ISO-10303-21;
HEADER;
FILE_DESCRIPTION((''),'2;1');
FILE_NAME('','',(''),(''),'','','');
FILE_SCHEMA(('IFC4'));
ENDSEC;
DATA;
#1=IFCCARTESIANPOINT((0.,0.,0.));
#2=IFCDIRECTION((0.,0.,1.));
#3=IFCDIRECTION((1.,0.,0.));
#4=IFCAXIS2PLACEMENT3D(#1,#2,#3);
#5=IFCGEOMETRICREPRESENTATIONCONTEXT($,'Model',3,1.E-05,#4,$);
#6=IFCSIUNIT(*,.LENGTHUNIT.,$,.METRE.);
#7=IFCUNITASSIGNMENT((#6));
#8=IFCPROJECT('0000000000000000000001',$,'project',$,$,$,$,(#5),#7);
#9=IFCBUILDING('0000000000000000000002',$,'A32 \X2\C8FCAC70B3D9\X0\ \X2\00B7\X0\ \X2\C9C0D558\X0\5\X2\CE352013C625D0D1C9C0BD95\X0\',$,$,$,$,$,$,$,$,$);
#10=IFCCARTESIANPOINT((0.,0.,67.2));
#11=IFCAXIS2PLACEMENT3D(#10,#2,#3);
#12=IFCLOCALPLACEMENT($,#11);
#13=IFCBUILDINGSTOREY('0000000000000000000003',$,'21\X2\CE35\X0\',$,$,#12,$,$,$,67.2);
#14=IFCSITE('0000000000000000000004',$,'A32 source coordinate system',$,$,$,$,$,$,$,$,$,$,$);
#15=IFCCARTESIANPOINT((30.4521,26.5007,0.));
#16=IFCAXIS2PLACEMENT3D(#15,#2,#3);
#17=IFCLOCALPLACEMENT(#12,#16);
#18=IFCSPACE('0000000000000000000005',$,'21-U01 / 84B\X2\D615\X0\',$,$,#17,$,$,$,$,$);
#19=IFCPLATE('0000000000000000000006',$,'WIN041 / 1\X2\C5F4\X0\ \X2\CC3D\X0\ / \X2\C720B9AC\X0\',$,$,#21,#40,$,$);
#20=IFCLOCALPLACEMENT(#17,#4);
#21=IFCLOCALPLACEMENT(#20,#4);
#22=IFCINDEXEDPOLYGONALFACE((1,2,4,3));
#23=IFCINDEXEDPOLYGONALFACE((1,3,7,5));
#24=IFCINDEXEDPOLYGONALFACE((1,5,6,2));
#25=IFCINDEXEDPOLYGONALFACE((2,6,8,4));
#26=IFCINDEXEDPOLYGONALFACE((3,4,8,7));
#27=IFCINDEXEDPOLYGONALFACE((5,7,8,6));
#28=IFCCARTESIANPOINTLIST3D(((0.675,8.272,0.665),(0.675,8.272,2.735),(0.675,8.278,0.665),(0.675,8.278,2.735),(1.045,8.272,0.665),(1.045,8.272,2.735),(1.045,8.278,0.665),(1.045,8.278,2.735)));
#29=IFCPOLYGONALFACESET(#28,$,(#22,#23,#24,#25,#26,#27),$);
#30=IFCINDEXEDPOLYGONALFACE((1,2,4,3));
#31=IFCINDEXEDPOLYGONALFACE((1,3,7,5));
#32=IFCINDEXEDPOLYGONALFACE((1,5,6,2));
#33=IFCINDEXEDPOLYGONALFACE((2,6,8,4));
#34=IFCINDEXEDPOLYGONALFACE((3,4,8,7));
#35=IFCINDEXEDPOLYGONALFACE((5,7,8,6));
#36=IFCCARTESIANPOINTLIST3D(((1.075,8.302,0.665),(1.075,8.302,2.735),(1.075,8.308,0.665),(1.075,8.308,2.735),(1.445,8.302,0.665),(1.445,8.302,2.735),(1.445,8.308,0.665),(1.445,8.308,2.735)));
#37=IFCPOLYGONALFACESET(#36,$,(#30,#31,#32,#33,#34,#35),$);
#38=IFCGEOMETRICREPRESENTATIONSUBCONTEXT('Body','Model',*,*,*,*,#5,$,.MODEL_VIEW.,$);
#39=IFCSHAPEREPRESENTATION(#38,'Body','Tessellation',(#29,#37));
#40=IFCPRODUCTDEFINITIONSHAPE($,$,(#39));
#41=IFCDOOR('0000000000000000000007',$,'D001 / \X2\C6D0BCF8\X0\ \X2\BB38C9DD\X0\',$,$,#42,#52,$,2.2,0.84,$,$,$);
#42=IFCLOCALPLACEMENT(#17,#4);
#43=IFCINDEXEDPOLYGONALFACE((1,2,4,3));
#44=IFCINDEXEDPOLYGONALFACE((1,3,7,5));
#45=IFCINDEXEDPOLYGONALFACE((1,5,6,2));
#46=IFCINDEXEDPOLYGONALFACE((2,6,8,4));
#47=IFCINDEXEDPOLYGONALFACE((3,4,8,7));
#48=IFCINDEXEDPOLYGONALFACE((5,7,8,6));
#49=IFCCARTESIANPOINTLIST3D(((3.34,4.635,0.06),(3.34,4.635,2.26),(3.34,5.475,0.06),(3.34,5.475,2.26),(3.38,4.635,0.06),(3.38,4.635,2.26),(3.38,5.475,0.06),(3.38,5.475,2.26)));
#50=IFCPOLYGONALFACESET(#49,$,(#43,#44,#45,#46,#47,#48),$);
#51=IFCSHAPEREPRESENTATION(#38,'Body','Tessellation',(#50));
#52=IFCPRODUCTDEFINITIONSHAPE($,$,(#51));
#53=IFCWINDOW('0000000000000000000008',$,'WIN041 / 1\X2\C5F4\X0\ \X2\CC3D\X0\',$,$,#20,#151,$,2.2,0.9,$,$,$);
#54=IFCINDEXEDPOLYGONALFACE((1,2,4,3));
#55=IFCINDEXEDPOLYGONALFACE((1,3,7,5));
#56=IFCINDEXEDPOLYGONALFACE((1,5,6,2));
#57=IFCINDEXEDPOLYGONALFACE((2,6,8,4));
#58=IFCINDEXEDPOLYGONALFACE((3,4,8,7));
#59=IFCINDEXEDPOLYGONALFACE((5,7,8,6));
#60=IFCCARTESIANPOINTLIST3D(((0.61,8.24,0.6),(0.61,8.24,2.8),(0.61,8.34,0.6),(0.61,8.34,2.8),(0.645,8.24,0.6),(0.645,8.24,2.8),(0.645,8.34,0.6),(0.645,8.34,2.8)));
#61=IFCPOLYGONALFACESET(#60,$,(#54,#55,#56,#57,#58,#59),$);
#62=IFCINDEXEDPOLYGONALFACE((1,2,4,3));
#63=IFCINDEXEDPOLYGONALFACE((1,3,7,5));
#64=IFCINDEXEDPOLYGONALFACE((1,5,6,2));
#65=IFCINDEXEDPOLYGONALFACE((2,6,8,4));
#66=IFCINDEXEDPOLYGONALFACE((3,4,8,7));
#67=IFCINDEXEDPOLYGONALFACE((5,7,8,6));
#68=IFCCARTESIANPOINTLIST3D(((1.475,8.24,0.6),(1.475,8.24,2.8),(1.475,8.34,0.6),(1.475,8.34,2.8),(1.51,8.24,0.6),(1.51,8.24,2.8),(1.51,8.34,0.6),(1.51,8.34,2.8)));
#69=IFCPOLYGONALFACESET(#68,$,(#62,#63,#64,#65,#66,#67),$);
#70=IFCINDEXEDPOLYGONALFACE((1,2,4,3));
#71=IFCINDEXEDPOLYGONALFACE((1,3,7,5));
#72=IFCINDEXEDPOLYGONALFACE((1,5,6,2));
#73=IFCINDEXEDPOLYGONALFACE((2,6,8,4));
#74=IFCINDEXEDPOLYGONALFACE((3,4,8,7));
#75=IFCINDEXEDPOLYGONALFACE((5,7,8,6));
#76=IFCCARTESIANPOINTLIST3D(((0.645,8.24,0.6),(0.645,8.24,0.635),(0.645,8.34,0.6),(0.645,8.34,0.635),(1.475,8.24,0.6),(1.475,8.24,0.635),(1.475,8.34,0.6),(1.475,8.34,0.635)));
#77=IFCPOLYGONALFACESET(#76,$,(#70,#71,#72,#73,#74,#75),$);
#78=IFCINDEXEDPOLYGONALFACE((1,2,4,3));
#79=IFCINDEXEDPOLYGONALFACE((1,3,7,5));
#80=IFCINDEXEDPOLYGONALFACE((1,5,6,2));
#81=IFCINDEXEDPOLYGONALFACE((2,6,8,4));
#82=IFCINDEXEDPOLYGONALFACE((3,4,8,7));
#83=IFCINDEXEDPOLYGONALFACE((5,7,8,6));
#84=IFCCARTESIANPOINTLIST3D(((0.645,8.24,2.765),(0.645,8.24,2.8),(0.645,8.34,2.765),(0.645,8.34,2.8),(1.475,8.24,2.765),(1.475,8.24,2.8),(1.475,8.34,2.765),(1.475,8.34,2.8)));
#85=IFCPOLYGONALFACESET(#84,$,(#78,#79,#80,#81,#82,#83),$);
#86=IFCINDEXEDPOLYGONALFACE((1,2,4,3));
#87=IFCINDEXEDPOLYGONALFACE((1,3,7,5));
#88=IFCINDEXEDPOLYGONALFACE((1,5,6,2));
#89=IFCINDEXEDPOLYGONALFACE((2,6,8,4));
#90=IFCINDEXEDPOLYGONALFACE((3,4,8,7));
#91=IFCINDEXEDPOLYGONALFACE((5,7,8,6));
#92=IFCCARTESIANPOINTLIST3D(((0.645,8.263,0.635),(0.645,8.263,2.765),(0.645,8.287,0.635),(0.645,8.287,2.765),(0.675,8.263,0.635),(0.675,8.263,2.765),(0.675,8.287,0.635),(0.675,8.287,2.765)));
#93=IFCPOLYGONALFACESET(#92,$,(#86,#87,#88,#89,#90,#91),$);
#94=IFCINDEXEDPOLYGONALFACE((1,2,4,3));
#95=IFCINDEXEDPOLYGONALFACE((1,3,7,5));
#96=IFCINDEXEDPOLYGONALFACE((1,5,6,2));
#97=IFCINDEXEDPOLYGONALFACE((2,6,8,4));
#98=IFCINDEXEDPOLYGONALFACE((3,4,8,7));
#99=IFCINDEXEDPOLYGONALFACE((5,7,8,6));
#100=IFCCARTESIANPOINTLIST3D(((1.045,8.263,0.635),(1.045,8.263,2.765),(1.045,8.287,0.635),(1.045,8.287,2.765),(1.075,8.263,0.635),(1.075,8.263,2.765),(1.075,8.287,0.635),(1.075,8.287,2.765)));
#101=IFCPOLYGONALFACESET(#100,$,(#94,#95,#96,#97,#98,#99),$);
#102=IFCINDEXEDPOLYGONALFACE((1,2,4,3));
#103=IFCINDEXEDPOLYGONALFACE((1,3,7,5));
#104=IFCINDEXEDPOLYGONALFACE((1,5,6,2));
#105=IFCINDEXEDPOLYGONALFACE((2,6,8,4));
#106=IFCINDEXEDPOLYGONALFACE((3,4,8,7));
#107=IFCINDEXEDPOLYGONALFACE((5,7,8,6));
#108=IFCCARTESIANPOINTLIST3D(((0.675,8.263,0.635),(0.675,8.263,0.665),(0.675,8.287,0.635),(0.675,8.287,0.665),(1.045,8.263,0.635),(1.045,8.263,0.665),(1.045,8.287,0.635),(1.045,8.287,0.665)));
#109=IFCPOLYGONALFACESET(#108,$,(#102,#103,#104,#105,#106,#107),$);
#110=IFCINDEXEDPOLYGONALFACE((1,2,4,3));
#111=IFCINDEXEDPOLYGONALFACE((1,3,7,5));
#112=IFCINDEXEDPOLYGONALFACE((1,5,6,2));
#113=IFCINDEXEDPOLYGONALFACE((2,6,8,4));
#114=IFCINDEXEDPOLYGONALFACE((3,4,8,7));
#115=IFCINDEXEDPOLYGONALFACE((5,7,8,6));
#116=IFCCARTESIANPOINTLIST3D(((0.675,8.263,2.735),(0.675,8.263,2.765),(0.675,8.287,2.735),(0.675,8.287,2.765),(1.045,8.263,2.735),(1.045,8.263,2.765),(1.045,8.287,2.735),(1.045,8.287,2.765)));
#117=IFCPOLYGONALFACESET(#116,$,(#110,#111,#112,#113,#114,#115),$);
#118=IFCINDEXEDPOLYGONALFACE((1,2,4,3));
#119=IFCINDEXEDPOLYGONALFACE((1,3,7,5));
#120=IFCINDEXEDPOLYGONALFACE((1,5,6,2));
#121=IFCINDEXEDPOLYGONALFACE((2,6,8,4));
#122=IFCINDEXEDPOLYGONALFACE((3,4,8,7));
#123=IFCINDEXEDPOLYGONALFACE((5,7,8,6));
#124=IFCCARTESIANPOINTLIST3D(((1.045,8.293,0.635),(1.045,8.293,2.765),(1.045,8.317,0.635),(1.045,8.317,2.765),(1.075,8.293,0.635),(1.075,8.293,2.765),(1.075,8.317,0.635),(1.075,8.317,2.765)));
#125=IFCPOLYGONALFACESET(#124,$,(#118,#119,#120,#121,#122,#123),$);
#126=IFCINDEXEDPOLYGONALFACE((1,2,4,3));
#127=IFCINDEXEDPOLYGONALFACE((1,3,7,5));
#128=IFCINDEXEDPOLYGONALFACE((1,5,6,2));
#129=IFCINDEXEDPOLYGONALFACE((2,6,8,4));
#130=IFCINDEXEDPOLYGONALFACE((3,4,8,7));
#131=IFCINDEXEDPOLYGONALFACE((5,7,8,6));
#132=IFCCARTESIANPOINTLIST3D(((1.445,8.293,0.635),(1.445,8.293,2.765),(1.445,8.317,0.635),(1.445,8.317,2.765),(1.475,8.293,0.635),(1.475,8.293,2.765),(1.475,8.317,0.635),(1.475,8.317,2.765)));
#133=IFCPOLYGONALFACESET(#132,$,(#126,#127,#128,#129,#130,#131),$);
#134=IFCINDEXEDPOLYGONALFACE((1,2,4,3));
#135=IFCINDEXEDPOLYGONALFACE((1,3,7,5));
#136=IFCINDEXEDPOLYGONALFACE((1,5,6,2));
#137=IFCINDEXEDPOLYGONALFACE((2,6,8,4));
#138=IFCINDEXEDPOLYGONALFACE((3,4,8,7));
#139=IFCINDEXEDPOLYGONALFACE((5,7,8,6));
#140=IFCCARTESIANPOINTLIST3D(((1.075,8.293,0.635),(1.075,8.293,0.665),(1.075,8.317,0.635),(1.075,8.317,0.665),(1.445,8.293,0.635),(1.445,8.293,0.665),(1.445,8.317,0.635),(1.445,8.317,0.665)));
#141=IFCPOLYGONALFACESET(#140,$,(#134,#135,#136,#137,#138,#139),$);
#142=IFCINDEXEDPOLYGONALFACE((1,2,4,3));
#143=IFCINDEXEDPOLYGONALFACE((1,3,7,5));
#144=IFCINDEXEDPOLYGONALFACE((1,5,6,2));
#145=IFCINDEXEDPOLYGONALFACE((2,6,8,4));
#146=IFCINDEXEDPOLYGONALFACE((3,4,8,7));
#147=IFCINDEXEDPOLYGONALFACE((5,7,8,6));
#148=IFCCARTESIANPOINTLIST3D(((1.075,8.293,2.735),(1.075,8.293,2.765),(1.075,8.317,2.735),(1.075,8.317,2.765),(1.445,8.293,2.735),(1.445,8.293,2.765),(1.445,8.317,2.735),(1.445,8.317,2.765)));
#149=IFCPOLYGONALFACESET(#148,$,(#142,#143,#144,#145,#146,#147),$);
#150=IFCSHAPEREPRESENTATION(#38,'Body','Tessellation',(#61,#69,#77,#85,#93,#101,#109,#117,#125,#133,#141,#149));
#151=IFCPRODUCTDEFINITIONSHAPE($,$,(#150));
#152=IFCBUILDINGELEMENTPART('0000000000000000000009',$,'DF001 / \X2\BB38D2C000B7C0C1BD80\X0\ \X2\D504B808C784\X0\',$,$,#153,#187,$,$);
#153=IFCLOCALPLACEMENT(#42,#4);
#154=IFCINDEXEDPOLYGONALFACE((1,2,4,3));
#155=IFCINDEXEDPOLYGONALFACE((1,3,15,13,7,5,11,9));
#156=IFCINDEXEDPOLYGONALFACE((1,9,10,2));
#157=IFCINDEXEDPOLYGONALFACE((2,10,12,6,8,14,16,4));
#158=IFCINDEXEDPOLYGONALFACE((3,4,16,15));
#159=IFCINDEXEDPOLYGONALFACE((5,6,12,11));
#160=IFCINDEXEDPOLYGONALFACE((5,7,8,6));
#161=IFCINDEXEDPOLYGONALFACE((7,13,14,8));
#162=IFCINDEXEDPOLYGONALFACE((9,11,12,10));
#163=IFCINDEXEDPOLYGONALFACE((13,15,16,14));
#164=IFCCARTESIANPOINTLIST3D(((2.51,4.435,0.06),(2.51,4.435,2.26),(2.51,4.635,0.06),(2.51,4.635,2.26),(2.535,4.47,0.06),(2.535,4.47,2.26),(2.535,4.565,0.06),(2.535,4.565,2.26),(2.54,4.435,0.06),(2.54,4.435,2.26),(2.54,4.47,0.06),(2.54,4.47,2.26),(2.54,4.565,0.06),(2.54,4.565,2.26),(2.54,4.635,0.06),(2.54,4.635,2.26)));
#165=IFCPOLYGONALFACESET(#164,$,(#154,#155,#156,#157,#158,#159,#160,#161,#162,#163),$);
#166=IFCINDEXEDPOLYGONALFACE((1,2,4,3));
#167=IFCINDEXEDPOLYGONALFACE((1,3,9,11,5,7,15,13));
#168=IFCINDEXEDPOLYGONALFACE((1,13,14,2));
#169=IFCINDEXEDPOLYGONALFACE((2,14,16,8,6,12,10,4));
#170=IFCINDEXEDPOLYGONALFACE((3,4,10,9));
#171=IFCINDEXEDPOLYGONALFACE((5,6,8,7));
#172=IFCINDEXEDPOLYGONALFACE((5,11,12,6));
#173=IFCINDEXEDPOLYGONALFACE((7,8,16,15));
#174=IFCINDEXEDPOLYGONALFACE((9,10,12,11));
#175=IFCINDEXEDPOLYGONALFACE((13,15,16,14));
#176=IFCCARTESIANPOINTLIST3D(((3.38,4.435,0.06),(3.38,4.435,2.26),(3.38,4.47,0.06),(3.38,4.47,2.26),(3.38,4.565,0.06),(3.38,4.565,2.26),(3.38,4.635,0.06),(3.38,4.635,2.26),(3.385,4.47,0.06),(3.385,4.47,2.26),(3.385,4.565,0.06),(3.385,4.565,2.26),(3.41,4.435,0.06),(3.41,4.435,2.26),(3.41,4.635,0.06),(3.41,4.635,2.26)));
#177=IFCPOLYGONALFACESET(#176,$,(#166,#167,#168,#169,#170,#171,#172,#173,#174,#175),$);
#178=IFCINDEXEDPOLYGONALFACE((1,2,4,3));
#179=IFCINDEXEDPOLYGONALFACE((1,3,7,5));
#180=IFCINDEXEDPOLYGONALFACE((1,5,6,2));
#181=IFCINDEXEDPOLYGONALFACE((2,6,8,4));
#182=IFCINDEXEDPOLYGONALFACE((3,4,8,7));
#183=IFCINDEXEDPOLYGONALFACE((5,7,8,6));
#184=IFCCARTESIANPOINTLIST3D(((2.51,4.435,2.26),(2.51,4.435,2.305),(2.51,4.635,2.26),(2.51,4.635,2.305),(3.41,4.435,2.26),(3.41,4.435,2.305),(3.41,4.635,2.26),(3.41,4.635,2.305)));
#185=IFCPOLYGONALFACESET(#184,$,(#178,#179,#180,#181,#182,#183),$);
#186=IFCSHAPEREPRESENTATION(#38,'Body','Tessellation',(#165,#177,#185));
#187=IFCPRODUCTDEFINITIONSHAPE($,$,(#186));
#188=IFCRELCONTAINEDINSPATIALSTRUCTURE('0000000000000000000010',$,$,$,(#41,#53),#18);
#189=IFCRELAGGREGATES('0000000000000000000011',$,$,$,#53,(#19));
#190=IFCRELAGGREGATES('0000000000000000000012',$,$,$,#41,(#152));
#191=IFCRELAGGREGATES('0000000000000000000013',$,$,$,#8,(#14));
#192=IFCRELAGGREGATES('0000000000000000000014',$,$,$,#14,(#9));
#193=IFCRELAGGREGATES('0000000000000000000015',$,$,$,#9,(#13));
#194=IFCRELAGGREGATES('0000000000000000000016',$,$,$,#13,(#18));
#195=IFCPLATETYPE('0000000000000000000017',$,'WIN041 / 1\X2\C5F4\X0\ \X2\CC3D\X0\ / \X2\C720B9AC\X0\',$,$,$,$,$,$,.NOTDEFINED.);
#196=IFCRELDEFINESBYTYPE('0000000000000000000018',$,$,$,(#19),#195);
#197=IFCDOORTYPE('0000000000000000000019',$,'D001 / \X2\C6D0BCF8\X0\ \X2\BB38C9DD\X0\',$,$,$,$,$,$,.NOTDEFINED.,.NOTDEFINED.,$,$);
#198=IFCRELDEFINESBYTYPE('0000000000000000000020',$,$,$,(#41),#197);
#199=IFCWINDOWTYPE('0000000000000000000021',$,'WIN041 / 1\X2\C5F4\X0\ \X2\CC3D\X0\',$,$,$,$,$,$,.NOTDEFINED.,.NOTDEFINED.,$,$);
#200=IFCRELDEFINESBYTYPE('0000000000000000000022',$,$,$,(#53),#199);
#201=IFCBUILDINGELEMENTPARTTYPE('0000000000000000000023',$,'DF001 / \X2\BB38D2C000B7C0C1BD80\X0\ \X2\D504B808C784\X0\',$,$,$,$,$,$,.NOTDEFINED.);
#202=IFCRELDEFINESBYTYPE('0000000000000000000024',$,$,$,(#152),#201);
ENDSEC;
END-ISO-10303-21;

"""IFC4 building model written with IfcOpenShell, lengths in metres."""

from ifc_helpers import new_model, si_unit, frame, origin, origin_with_axes, place, context, subcontext, project, spatial, polyline, outline, extrude, source, transform, mapped, type_object, type_shapes, element, aggregate, save


model = new_model("IFC4")

# Units and contexts
model_context = context("Model", 3, precision=1e-05, world=origin_with_axes())
body_context = subcontext(model_context, "Body", "Model", "MODEL_VIEW")
ifc_project = project(units=[si_unit("LENGTHUNIT", "METRE")], contexts=[model_context])

# Plate
storey_placement = place(None, frame((0.0, 0.0, 67.2), z_axis=(0.0, 0.0, 1.0), x_axis=(1.0, 0.0, 0.0)))
space_placement = place(storey_placement, frame((30.4521, 26.5007, 0.0), z_axis=(0.0, 0.0, 1.0), x_axis=(1.0, 0.0, 0.0)))
plate_type_1 = type_object("IfcPlateType", Name="WIN041 / 1열 창 / 유리", PredefinedType="NOTDEFINED")
shared_shape_1 = source(origin(), body_context, "Body", "SweptSolid", [
    extrude(outline(polyline([(0.675, 8.272), (0.675, 8.278), (1.045, 8.278), (1.045, 8.272), (0.675, 8.272)])), frame((0.0, 0.0, 0.665)), (0.0, 0.0, 1.0), 2.07),
    extrude(outline(polyline([(1.075, 8.302), (1.075, 8.308), (1.445, 8.308), (1.445, 8.302), (1.075, 8.302)])), frame((0.0, 0.0, 0.665)), (0.0, 0.0, 1.0), 2.07),
])
type_shapes(plate_type_1, [shared_shape_1])
window_1_placement = place(space_placement, origin_with_axes())
plate_1_placement = place(window_1_placement, origin_with_axes())
plate_1 = element("IfcPlate", 1, at=plate_1_placement, type_object=plate_type_1, Name="WIN041 / 1열 창 / 유리", context=body_context, shape_type="MappedRepresentation", body=[
    mapped(shared_shape_1, transform((0.0, 0.0, 0.0), scale=1.0)),
])

# Site, building, storey, space
site = spatial("IfcSite", under=ifc_project, Name="A32 source coordinate system")
building = spatial("IfcBuilding", under=site, Name="A32 주거동 · 지하5층–옥탑지붕")
storey = spatial("IfcBuildingStorey", under=building, at=storey_placement, Name="21층", Elevation=67.2)
space = spatial("IfcSpace", under=storey, at=space_placement, Name="21-U01 / 84B형")

# Door
door_type_1 = type_object("IfcDoorType", Name="D001 / 원본 문짝", OperationType="NOTDEFINED", PredefinedType="NOTDEFINED")
shared_shape_2 = source(origin(), body_context, "Body", "SweptSolid", [
    extrude(outline(polyline([(3.34, 5.475), (3.38, 5.475), (3.38, 4.635), (3.34, 4.635), (3.34, 5.475)])), frame((0.0, 0.0, 0.06)), (0.0, 0.0, 1.0), 2.2),
])
type_shapes(door_type_1, [shared_shape_2])
door_1_placement = place(space_placement, origin_with_axes())
door_1 = element("IfcDoor", 2, at=door_1_placement, inside=space, type_object=door_type_1, Name="D001 / 원본 문짝", OverallHeight=2.2, OverallWidth=0.84, context=body_context, shape_type="MappedRepresentation", body=[
    mapped(shared_shape_2, transform((0.0, 0.0, 0.0), scale=1.0)),
])

# Window
window_type_1 = type_object("IfcWindowType", Name="WIN041 / 1열 창", PartitioningType="NOTDEFINED", PredefinedType="NOTDEFINED")
shared_shape_3 = source(origin(), body_context, "Body", "SweptSolid", [
    extrude(outline(polyline([(0.61, 8.24), (0.61, 8.34), (0.645, 8.34), (0.645, 8.24), (0.61, 8.24)])), frame((0.0, 0.0, 0.6)), (0.0, 0.0, 1.0), 2.2),
    extrude(outline(polyline([(1.475, 8.24), (1.475, 8.34), (1.51, 8.34), (1.51, 8.24), (1.475, 8.24)])), frame((0.0, 0.0, 0.6)), (0.0, 0.0, 1.0), 2.2),
    extrude(outline(polyline([(0.645, 8.24), (0.645, 8.34), (1.475, 8.34), (1.475, 8.24), (0.645, 8.24)])), frame((0.0, 0.0, 0.6)), (0.0, 0.0, 1.0), 0.035),
    extrude(outline(polyline([(0.645, 8.24), (0.645, 8.34), (1.475, 8.34), (1.475, 8.24), (0.645, 8.24)])), frame((0.0, 0.0, 2.765)), (0.0, 0.0, 1.0), 0.035),
    extrude(outline(polyline([(0.645, 8.263), (0.645, 8.287), (0.675, 8.287), (0.675, 8.263), (0.645, 8.263)])), frame((0.0, 0.0, 0.635)), (0.0, 0.0, 1.0), 2.13),
    extrude(outline(polyline([(1.045, 8.263), (1.045, 8.287), (1.075, 8.287), (1.075, 8.263), (1.045, 8.263)])), frame((0.0, 0.0, 0.635)), (0.0, 0.0, 1.0), 2.13),
    extrude(outline(polyline([(0.675, 8.263), (0.675, 8.287), (1.045, 8.287), (1.045, 8.263), (0.675, 8.263)])), frame((0.0, 0.0, 0.635)), (0.0, 0.0, 1.0), 0.03),
    extrude(outline(polyline([(0.675, 8.263), (0.675, 8.287), (1.045, 8.287), (1.045, 8.263), (0.675, 8.263)])), frame((0.0, 0.0, 2.735)), (0.0, 0.0, 1.0), 0.03),
    extrude(outline(polyline([(1.045, 8.293), (1.045, 8.317), (1.075, 8.317), (1.075, 8.293), (1.045, 8.293)])), frame((0.0, 0.0, 0.635)), (0.0, 0.0, 1.0), 2.13),
    extrude(outline(polyline([(1.445, 8.293), (1.445, 8.317), (1.475, 8.317), (1.475, 8.293), (1.445, 8.293)])), frame((0.0, 0.0, 0.635)), (0.0, 0.0, 1.0), 2.13),
    extrude(outline(polyline([(1.075, 8.293), (1.075, 8.317), (1.445, 8.317), (1.445, 8.293), (1.075, 8.293)])), frame((0.0, 0.0, 0.635)), (0.0, 0.0, 1.0), 0.03),
    extrude(outline(polyline([(1.075, 8.293), (1.075, 8.317), (1.445, 8.317), (1.445, 8.293), (1.075, 8.293)])), frame((0.0, 0.0, 2.735)), (0.0, 0.0, 1.0), 0.03),
])
type_shapes(window_type_1, [shared_shape_3])
window_1 = element("IfcWindow", 3, at=window_1_placement, inside=space, type_object=window_type_1, Name="WIN041 / 1열 창", OverallHeight=2.2, OverallWidth=0.9, context=body_context, shape_type="MappedRepresentation", body=[
    mapped(shared_shape_3, transform((0.0, 0.0, 0.0), scale=1.0)),
])
aggregate(window_1, [plate_1])

# Building element part
building_element_part_type_1 = type_object("IfcBuildingElementPartType", Name="DF001 / 문틀·상부 프레임", PredefinedType="NOTDEFINED")
shared_shape_4 = source(origin(), body_context, "Body", "SweptSolid", [
    extrude(outline(polyline([(2.54, 4.635), (2.54, 4.565), (2.535, 4.565), (2.535, 4.47), (2.54, 4.47), (2.54, 4.435), (2.51, 4.435), (2.51, 4.635), (2.54, 4.635)])), frame((0.0, 0.0, 0.06)), (0.0, 0.0, 1.0), 2.2),
    extrude(outline(polyline([(3.41, 4.435), (3.38, 4.435), (3.38, 4.47), (3.385, 4.47), (3.385, 4.565), (3.38, 4.565), (3.38, 4.635), (3.41, 4.635), (3.41, 4.435)])), frame((0.0, 0.0, 0.06)), (0.0, 0.0, 1.0), 2.2),
    extrude(outline(polyline([(2.51, 4.435), (2.51, 4.635), (3.41, 4.635), (3.41, 4.435), (2.51, 4.435)])), frame((0.0, 0.0, 2.26)), (0.0, 0.0, 1.0), 0.045),
])
type_shapes(building_element_part_type_1, [shared_shape_4])
building_element_part_1_placement = place(door_1_placement, origin_with_axes())
building_element_part_1 = element("IfcBuildingElementPart", 4, at=building_element_part_1_placement, type_object=building_element_part_type_1, Name="DF001 / 문틀·상부 프레임", context=body_context, shape_type="MappedRepresentation", body=[
    mapped(shared_shape_4, transform((0.0, 0.0, 0.0), scale=1.0)),
])
aggregate(door_1, [building_element_part_1])

save(model, "model.ifc")
